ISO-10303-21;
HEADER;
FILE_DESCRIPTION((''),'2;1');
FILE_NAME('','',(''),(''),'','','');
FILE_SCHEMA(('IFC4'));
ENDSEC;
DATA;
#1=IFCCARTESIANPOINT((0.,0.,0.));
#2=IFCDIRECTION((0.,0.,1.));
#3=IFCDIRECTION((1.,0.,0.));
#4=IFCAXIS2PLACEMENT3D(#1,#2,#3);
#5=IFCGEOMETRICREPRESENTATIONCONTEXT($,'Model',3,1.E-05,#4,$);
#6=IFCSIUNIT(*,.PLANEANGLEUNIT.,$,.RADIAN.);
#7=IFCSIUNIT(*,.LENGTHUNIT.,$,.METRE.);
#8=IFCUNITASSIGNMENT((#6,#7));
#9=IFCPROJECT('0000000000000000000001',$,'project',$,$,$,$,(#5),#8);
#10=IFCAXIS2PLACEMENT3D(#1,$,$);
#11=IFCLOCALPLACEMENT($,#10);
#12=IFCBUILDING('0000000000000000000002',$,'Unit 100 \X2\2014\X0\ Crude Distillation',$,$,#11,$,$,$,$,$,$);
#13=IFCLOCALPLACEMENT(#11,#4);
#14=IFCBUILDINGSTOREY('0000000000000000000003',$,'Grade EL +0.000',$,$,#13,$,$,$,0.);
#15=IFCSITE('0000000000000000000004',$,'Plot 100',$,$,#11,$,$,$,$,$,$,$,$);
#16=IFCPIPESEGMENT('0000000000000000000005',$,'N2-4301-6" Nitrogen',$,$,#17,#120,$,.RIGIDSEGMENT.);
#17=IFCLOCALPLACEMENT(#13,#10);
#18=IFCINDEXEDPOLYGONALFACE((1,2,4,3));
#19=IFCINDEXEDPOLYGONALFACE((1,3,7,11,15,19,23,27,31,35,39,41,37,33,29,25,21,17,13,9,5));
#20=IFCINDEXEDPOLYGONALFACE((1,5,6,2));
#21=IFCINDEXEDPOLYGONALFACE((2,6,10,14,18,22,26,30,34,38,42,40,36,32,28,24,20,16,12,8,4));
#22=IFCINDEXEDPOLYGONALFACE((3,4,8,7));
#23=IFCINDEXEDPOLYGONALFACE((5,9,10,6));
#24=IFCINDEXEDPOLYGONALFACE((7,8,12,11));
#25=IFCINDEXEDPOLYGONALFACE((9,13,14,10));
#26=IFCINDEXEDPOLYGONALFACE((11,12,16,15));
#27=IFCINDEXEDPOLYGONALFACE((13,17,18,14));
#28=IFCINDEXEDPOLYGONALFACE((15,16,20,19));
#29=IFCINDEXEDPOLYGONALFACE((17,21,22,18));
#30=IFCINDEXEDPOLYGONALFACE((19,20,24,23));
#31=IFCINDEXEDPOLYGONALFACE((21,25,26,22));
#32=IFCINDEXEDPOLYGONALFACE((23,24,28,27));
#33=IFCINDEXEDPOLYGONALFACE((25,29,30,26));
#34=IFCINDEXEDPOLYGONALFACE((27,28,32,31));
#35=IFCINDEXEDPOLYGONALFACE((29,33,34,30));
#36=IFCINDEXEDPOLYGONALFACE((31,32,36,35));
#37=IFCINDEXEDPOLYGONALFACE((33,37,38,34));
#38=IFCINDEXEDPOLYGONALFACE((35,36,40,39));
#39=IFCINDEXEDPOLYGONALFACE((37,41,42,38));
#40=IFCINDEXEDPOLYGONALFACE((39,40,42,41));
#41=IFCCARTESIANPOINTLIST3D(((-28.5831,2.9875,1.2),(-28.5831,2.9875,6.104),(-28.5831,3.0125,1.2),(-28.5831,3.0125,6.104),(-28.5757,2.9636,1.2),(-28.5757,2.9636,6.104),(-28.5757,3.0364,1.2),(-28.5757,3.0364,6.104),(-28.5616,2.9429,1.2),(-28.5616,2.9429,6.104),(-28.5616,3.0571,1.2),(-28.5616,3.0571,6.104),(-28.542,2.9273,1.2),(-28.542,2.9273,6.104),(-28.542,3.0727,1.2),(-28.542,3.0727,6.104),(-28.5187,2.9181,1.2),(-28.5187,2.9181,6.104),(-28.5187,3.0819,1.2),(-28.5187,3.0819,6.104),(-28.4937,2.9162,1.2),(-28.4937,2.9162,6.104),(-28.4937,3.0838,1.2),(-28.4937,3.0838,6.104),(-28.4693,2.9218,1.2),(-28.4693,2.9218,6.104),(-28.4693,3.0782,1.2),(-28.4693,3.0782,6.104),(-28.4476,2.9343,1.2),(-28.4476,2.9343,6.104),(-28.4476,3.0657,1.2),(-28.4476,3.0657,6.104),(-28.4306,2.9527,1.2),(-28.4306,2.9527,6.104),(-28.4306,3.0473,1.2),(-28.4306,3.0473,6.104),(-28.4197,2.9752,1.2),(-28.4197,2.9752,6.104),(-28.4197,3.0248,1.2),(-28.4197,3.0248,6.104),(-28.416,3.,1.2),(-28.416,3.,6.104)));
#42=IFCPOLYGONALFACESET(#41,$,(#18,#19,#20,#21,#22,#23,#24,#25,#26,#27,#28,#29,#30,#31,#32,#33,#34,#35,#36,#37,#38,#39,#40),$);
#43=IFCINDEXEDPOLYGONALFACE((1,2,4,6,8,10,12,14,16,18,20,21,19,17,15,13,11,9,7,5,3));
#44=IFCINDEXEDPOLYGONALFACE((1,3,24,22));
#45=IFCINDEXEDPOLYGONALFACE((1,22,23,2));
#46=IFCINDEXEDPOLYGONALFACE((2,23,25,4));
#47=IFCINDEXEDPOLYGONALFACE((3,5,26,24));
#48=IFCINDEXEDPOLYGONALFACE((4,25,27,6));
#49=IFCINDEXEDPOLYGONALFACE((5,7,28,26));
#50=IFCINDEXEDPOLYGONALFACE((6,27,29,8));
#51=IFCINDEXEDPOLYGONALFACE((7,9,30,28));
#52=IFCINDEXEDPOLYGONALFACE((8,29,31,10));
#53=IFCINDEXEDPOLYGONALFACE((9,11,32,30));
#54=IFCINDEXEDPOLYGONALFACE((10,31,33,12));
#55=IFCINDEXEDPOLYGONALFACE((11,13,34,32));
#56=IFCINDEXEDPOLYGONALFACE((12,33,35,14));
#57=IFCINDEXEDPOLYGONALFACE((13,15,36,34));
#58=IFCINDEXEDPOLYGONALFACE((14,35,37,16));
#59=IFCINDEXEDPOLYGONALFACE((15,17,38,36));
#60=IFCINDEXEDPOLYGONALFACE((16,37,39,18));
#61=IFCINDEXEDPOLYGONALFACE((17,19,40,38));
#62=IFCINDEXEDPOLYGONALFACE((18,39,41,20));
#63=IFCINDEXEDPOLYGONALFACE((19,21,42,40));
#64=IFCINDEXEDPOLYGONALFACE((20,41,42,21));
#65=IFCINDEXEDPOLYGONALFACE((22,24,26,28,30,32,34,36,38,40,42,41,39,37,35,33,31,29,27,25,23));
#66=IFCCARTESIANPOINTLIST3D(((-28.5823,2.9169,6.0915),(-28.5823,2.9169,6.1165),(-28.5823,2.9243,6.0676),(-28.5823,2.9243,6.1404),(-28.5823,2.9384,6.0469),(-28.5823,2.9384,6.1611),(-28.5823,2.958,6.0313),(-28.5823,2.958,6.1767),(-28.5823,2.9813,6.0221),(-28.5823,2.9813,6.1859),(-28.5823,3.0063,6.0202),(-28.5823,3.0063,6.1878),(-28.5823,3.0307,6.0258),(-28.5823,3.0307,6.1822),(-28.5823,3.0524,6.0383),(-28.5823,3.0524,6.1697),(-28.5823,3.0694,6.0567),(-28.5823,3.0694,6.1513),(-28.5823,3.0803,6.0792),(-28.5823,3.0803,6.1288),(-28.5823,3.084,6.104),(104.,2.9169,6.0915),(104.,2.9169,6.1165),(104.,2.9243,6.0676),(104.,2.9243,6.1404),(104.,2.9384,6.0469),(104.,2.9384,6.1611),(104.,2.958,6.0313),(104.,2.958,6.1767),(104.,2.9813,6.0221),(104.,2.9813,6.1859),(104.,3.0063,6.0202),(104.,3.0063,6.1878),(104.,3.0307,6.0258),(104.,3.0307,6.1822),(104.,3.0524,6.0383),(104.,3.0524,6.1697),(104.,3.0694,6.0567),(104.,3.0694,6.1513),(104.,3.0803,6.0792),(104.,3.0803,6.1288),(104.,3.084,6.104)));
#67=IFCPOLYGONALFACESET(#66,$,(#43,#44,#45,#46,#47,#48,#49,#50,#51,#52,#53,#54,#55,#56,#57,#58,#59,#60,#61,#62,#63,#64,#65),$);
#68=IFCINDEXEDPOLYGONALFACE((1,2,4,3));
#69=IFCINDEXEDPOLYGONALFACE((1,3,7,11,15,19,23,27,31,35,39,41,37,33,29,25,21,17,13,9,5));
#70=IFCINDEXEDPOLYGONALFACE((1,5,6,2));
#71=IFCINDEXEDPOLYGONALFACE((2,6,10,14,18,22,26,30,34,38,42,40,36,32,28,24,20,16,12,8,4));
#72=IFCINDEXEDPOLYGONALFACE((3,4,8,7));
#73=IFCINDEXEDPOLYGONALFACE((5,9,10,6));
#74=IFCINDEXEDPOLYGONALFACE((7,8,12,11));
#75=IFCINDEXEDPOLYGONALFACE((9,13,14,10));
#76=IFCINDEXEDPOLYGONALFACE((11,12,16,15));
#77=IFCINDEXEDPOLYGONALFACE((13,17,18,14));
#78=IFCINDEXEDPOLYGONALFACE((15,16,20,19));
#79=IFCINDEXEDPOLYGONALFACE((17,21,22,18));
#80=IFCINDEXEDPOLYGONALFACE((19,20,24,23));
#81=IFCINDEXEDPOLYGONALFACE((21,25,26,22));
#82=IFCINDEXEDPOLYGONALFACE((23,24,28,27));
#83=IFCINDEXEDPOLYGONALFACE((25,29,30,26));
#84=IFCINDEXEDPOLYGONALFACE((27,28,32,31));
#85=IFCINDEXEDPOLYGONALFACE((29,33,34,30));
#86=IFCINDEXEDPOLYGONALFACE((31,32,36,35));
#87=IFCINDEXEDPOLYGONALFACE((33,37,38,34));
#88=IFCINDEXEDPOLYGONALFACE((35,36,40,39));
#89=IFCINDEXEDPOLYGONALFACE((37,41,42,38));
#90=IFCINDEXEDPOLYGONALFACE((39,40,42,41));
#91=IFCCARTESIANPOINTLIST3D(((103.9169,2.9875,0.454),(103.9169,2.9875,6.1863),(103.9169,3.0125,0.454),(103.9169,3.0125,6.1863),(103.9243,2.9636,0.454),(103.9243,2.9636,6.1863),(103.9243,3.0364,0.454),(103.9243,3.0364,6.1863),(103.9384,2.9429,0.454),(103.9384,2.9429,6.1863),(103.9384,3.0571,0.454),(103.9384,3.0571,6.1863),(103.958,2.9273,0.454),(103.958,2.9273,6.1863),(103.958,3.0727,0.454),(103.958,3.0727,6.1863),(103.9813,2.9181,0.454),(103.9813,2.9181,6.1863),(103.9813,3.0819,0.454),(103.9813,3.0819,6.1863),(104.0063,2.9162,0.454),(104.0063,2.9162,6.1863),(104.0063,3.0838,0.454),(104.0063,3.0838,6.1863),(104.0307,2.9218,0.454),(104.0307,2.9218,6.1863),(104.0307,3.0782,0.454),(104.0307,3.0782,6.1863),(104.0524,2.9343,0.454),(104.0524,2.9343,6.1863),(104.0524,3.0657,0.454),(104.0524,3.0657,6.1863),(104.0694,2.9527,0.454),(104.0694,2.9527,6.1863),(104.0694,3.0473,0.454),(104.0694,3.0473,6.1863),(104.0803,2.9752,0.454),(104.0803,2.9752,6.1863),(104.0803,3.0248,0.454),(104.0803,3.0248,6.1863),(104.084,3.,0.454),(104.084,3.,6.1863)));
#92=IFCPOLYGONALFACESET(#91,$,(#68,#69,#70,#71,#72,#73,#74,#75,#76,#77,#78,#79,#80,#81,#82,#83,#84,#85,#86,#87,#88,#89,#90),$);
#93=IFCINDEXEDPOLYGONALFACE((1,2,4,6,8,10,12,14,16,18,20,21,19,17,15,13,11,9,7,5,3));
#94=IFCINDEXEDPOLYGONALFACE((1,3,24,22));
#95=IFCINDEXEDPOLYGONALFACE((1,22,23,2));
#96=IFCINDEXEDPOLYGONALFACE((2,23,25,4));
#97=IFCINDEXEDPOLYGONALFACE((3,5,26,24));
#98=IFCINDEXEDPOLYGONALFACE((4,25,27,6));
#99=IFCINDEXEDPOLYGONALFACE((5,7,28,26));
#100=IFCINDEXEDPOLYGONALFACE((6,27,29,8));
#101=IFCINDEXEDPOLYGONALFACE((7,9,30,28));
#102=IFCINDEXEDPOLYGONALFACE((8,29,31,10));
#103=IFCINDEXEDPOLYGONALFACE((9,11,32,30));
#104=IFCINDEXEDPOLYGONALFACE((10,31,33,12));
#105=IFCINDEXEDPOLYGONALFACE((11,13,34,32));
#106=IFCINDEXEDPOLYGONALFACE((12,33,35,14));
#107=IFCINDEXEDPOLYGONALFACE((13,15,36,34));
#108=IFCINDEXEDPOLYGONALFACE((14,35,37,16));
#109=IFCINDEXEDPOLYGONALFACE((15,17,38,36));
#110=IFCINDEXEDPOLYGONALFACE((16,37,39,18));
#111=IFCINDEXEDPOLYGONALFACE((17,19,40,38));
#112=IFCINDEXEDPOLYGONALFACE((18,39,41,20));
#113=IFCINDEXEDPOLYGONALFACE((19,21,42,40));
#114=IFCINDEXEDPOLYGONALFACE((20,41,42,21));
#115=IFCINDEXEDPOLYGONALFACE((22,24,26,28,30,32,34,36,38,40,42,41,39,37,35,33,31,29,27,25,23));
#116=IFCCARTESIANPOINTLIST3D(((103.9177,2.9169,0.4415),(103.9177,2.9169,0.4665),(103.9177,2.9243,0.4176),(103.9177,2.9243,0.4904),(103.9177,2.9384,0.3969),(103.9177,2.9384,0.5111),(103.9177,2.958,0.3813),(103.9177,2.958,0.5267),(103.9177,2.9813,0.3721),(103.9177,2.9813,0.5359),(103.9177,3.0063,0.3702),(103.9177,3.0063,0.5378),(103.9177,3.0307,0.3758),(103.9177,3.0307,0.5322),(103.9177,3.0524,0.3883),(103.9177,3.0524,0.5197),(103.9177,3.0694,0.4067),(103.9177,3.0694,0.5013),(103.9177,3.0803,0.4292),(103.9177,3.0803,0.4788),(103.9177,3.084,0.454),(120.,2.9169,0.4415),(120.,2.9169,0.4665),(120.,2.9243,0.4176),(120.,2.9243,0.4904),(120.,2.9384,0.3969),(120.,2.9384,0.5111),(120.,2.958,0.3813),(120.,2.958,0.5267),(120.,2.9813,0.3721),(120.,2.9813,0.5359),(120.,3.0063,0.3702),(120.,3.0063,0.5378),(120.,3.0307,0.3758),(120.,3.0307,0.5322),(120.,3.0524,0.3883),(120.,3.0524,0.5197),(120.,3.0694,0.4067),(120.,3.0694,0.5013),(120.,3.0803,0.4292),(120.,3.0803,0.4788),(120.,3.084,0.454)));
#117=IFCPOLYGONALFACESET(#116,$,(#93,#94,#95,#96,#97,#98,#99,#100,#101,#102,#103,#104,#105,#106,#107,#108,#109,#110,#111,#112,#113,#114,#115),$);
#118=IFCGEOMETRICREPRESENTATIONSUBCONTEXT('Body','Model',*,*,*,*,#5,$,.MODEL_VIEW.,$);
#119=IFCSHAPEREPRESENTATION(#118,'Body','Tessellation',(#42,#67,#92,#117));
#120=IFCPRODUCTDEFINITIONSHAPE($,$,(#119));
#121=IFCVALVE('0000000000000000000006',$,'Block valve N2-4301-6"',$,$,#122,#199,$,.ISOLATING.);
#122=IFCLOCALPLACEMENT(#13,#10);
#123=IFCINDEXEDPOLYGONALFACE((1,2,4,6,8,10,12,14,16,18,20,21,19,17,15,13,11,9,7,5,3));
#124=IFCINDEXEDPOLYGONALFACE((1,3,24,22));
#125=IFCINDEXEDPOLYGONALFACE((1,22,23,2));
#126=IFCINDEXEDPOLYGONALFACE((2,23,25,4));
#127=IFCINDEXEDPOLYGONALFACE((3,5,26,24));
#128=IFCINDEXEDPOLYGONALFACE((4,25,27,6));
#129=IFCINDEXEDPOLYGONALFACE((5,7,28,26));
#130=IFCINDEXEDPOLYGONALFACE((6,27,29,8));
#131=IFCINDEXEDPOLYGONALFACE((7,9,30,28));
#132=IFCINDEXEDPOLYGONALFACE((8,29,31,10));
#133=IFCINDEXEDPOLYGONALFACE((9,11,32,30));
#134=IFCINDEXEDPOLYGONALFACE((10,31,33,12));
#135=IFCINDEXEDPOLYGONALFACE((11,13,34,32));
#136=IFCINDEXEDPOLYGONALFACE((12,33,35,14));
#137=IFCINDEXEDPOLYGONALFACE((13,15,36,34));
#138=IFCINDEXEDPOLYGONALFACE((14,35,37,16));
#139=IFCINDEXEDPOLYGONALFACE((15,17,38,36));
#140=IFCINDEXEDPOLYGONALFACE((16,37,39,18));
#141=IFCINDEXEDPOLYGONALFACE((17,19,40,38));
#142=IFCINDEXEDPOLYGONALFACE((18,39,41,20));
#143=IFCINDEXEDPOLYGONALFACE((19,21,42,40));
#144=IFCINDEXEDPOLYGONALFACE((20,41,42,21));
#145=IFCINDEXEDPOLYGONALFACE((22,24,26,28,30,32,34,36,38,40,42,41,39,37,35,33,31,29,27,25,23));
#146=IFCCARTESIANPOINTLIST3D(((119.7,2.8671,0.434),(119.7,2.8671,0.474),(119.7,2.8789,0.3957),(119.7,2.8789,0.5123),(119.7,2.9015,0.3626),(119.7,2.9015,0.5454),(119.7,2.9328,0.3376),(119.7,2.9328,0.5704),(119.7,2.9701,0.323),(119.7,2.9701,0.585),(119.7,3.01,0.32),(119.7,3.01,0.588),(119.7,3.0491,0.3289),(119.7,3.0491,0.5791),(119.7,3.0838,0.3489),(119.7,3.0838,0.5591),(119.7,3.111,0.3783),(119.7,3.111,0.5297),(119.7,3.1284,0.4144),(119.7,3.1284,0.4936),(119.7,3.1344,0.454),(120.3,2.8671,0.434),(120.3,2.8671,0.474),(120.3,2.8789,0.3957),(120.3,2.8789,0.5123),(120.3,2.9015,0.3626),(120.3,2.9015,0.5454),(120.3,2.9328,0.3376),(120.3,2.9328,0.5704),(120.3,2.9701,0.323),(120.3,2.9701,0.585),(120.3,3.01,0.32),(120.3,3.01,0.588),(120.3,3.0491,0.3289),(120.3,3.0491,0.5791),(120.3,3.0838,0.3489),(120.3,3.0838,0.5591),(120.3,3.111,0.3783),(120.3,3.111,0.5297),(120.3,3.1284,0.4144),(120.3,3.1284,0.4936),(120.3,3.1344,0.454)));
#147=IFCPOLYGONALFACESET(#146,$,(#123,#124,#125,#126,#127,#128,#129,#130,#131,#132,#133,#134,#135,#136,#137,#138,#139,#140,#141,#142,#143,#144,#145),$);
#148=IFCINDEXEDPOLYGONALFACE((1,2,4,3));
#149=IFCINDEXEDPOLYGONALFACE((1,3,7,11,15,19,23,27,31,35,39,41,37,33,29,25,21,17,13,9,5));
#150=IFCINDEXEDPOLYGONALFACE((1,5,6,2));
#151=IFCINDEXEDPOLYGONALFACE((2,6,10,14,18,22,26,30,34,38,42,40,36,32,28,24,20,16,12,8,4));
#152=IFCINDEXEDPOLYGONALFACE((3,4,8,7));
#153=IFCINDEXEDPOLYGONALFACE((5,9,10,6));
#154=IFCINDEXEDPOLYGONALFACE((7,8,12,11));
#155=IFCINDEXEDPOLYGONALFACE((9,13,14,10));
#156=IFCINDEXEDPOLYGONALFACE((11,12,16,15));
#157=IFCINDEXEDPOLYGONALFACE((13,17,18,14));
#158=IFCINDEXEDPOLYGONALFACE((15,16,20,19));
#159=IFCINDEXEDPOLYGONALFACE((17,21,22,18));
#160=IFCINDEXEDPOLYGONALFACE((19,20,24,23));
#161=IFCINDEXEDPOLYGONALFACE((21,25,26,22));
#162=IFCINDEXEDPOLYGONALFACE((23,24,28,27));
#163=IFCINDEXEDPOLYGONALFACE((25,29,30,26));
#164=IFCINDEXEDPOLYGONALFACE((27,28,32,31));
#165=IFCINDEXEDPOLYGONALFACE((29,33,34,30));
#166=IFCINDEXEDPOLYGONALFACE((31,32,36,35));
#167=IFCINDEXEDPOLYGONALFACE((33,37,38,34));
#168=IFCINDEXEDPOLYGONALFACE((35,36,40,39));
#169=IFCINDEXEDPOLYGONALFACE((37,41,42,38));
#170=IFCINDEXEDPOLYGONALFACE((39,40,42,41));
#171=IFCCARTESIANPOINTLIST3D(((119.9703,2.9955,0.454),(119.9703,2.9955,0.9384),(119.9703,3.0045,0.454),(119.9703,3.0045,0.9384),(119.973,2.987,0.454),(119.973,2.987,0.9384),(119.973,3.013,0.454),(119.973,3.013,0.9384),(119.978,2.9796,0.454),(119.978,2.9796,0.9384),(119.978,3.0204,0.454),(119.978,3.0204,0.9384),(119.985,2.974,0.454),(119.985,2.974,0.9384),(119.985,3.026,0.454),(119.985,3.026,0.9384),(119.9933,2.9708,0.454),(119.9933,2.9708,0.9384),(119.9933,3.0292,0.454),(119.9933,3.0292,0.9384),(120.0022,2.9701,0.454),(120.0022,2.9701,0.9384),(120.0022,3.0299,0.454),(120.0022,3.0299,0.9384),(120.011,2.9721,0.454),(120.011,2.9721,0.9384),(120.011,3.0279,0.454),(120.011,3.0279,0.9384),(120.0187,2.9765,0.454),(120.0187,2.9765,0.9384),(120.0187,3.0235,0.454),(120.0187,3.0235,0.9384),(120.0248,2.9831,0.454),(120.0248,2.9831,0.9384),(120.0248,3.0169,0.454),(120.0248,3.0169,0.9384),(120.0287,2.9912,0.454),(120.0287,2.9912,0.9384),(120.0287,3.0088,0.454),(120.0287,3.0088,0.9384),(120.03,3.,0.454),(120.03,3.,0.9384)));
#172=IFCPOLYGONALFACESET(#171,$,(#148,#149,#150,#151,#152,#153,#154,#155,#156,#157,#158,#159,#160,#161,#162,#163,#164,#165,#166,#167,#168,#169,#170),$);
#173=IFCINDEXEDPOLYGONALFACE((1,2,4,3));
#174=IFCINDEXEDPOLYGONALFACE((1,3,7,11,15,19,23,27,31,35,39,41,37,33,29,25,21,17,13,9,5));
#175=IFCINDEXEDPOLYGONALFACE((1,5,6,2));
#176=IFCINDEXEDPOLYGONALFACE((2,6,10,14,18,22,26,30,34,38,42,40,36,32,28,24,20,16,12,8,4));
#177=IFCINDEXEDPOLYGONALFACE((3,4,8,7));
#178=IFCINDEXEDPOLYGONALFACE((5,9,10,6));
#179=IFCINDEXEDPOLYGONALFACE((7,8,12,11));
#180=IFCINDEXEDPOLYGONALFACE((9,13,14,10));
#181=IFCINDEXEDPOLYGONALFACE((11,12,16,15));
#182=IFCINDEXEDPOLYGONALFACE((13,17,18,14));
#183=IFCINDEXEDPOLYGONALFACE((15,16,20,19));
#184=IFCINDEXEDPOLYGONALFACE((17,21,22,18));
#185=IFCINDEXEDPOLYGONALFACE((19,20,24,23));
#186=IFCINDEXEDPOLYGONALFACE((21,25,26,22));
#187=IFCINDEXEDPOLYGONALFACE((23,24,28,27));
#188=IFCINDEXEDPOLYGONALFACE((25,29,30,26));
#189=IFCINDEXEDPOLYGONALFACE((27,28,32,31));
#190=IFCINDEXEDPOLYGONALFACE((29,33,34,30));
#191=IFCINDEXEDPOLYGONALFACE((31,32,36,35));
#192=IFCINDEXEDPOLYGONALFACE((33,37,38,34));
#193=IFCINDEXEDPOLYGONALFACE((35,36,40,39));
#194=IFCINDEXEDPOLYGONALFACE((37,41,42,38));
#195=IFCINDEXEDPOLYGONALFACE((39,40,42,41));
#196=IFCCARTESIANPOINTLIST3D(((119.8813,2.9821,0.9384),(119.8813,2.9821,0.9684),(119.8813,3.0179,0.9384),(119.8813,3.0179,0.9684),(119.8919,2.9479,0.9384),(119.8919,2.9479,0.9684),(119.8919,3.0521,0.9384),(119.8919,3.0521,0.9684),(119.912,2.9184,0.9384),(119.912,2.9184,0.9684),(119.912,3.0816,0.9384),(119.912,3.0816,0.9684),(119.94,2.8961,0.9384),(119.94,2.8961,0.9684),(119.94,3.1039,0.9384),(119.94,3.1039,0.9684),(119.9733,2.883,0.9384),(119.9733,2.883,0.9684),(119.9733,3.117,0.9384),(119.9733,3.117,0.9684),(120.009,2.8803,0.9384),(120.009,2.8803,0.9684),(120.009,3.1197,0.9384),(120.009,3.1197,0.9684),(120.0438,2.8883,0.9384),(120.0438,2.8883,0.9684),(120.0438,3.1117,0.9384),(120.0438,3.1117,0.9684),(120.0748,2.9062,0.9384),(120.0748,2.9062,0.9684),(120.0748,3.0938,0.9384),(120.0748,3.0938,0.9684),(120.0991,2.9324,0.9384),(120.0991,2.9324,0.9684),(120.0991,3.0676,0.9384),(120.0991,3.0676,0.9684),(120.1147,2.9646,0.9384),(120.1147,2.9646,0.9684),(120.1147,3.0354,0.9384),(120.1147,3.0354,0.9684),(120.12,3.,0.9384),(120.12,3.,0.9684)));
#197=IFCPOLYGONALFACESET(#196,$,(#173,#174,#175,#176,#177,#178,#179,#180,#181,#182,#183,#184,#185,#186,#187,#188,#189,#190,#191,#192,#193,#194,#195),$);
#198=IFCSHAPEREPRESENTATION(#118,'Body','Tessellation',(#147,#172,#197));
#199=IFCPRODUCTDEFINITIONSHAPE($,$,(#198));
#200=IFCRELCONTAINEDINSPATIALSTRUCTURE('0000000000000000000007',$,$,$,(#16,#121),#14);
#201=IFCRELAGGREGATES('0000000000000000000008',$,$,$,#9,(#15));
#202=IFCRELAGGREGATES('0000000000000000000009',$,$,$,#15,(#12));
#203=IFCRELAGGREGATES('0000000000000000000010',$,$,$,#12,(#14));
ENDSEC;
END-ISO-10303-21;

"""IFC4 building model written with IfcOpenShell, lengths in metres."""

from ifc_helpers import new_model, si_unit, frame, origin, origin_with_axes, origin_2d, place, context, subcontext, project, spatial, circle, extrude, element, save


model = new_model("IFC4")

# Units and contexts
model_context = context("Model", 3, precision=1e-05, world=origin_with_axes())
body_context = subcontext(model_context, "Body", "Model", "MODEL_VIEW")
ifc_project = project(units=[si_unit("PLANEANGLEUNIT", "RADIAN"), si_unit("LENGTHUNIT", "METRE")], contexts=[model_context])

# Site, building, storey
placement = place(None, origin())
site = spatial("IfcSite", under=ifc_project, at=placement, Name="Plot 100")
building = spatial("IfcBuilding", under=site, at=placement, Name="Unit 100 — Crude Distillation")
storey_placement = place(placement, origin_with_axes())
storey = spatial("IfcBuildingStorey", under=building, at=storey_placement, Name="Grade EL +0.000", Elevation=0.0)

# Pipe segment
pipe_segment_1_placement = place(storey_placement, origin_with_axes())
element("IfcPipeSegment", 1, at=pipe_segment_1_placement, inside=storey, Name="N2-4301-6\" Nitrogen", PredefinedType="RIGIDSEGMENT", context=body_context, shape_type="SweptSolid", body=[
    extrude(circle(Radius=0.084, at=origin_2d()), frame((-28.5, 3.0, 1.2), z_axis=(0.0, 0.0, 1.0), x_axis=(1.0, 0.0, 0.0)), (0.0, 0.0, 1.0), 4.904),
    extrude(circle(Radius=0.084, at=origin_2d()), frame((-28.5823, 3.0, 6.104), z_axis=(1.0, 0.0, 0.0), x_axis=(0.0, 1.0, 0.0)), (0.0, 0.0, 1.0), 132.5823),
    extrude(circle(Radius=0.084, at=origin_2d()), frame((104.0, 3.0, 6.1863), z_axis=(0.0, 0.0, -1.0), x_axis=(1.0, 0.0, 0.0)), (0.0, 0.0, 1.0), 5.7323),
    extrude(circle(Radius=0.084, at=origin_2d()), frame((103.9177, 3.0, 0.454), z_axis=(1.0, 0.0, 0.0), x_axis=(0.0, 1.0, 0.0)), (0.0, 0.0, 1.0), 16.0823),
])

# Valve
valve_1_placement = place(storey_placement, origin_with_axes())
element("IfcValve", 2, at=valve_1_placement, inside=storey, Name="Block valve N2-4301-6\"", PredefinedType="ISOLATING", context=body_context, shape_type="SweptSolid", body=[
    extrude(circle(Radius=0.1344, at=origin_2d()), frame((119.7, 3.0, 0.454), z_axis=(1.0, 0.0, 0.0), x_axis=(0.0, 1.0, 0.0)), (0.0, 0.0, 1.0), 0.6),
    extrude(circle(Radius=0.03, at=origin_2d()), frame((120.0, 3.0, 0.454), z_axis=(0.0, 0.0, 1.0), x_axis=(1.0, 0.0, 0.0)), (0.0, 0.0, 1.0), 0.4844),
    extrude(circle(Radius=0.12, at=origin_2d()), frame((120.0, 3.0, 0.9384), z_axis=(0.0, 0.0, 1.0), x_axis=(1.0, 0.0, 0.0)), (0.0, 0.0, 1.0), 0.03),
])

save(model, "model.ifc")
